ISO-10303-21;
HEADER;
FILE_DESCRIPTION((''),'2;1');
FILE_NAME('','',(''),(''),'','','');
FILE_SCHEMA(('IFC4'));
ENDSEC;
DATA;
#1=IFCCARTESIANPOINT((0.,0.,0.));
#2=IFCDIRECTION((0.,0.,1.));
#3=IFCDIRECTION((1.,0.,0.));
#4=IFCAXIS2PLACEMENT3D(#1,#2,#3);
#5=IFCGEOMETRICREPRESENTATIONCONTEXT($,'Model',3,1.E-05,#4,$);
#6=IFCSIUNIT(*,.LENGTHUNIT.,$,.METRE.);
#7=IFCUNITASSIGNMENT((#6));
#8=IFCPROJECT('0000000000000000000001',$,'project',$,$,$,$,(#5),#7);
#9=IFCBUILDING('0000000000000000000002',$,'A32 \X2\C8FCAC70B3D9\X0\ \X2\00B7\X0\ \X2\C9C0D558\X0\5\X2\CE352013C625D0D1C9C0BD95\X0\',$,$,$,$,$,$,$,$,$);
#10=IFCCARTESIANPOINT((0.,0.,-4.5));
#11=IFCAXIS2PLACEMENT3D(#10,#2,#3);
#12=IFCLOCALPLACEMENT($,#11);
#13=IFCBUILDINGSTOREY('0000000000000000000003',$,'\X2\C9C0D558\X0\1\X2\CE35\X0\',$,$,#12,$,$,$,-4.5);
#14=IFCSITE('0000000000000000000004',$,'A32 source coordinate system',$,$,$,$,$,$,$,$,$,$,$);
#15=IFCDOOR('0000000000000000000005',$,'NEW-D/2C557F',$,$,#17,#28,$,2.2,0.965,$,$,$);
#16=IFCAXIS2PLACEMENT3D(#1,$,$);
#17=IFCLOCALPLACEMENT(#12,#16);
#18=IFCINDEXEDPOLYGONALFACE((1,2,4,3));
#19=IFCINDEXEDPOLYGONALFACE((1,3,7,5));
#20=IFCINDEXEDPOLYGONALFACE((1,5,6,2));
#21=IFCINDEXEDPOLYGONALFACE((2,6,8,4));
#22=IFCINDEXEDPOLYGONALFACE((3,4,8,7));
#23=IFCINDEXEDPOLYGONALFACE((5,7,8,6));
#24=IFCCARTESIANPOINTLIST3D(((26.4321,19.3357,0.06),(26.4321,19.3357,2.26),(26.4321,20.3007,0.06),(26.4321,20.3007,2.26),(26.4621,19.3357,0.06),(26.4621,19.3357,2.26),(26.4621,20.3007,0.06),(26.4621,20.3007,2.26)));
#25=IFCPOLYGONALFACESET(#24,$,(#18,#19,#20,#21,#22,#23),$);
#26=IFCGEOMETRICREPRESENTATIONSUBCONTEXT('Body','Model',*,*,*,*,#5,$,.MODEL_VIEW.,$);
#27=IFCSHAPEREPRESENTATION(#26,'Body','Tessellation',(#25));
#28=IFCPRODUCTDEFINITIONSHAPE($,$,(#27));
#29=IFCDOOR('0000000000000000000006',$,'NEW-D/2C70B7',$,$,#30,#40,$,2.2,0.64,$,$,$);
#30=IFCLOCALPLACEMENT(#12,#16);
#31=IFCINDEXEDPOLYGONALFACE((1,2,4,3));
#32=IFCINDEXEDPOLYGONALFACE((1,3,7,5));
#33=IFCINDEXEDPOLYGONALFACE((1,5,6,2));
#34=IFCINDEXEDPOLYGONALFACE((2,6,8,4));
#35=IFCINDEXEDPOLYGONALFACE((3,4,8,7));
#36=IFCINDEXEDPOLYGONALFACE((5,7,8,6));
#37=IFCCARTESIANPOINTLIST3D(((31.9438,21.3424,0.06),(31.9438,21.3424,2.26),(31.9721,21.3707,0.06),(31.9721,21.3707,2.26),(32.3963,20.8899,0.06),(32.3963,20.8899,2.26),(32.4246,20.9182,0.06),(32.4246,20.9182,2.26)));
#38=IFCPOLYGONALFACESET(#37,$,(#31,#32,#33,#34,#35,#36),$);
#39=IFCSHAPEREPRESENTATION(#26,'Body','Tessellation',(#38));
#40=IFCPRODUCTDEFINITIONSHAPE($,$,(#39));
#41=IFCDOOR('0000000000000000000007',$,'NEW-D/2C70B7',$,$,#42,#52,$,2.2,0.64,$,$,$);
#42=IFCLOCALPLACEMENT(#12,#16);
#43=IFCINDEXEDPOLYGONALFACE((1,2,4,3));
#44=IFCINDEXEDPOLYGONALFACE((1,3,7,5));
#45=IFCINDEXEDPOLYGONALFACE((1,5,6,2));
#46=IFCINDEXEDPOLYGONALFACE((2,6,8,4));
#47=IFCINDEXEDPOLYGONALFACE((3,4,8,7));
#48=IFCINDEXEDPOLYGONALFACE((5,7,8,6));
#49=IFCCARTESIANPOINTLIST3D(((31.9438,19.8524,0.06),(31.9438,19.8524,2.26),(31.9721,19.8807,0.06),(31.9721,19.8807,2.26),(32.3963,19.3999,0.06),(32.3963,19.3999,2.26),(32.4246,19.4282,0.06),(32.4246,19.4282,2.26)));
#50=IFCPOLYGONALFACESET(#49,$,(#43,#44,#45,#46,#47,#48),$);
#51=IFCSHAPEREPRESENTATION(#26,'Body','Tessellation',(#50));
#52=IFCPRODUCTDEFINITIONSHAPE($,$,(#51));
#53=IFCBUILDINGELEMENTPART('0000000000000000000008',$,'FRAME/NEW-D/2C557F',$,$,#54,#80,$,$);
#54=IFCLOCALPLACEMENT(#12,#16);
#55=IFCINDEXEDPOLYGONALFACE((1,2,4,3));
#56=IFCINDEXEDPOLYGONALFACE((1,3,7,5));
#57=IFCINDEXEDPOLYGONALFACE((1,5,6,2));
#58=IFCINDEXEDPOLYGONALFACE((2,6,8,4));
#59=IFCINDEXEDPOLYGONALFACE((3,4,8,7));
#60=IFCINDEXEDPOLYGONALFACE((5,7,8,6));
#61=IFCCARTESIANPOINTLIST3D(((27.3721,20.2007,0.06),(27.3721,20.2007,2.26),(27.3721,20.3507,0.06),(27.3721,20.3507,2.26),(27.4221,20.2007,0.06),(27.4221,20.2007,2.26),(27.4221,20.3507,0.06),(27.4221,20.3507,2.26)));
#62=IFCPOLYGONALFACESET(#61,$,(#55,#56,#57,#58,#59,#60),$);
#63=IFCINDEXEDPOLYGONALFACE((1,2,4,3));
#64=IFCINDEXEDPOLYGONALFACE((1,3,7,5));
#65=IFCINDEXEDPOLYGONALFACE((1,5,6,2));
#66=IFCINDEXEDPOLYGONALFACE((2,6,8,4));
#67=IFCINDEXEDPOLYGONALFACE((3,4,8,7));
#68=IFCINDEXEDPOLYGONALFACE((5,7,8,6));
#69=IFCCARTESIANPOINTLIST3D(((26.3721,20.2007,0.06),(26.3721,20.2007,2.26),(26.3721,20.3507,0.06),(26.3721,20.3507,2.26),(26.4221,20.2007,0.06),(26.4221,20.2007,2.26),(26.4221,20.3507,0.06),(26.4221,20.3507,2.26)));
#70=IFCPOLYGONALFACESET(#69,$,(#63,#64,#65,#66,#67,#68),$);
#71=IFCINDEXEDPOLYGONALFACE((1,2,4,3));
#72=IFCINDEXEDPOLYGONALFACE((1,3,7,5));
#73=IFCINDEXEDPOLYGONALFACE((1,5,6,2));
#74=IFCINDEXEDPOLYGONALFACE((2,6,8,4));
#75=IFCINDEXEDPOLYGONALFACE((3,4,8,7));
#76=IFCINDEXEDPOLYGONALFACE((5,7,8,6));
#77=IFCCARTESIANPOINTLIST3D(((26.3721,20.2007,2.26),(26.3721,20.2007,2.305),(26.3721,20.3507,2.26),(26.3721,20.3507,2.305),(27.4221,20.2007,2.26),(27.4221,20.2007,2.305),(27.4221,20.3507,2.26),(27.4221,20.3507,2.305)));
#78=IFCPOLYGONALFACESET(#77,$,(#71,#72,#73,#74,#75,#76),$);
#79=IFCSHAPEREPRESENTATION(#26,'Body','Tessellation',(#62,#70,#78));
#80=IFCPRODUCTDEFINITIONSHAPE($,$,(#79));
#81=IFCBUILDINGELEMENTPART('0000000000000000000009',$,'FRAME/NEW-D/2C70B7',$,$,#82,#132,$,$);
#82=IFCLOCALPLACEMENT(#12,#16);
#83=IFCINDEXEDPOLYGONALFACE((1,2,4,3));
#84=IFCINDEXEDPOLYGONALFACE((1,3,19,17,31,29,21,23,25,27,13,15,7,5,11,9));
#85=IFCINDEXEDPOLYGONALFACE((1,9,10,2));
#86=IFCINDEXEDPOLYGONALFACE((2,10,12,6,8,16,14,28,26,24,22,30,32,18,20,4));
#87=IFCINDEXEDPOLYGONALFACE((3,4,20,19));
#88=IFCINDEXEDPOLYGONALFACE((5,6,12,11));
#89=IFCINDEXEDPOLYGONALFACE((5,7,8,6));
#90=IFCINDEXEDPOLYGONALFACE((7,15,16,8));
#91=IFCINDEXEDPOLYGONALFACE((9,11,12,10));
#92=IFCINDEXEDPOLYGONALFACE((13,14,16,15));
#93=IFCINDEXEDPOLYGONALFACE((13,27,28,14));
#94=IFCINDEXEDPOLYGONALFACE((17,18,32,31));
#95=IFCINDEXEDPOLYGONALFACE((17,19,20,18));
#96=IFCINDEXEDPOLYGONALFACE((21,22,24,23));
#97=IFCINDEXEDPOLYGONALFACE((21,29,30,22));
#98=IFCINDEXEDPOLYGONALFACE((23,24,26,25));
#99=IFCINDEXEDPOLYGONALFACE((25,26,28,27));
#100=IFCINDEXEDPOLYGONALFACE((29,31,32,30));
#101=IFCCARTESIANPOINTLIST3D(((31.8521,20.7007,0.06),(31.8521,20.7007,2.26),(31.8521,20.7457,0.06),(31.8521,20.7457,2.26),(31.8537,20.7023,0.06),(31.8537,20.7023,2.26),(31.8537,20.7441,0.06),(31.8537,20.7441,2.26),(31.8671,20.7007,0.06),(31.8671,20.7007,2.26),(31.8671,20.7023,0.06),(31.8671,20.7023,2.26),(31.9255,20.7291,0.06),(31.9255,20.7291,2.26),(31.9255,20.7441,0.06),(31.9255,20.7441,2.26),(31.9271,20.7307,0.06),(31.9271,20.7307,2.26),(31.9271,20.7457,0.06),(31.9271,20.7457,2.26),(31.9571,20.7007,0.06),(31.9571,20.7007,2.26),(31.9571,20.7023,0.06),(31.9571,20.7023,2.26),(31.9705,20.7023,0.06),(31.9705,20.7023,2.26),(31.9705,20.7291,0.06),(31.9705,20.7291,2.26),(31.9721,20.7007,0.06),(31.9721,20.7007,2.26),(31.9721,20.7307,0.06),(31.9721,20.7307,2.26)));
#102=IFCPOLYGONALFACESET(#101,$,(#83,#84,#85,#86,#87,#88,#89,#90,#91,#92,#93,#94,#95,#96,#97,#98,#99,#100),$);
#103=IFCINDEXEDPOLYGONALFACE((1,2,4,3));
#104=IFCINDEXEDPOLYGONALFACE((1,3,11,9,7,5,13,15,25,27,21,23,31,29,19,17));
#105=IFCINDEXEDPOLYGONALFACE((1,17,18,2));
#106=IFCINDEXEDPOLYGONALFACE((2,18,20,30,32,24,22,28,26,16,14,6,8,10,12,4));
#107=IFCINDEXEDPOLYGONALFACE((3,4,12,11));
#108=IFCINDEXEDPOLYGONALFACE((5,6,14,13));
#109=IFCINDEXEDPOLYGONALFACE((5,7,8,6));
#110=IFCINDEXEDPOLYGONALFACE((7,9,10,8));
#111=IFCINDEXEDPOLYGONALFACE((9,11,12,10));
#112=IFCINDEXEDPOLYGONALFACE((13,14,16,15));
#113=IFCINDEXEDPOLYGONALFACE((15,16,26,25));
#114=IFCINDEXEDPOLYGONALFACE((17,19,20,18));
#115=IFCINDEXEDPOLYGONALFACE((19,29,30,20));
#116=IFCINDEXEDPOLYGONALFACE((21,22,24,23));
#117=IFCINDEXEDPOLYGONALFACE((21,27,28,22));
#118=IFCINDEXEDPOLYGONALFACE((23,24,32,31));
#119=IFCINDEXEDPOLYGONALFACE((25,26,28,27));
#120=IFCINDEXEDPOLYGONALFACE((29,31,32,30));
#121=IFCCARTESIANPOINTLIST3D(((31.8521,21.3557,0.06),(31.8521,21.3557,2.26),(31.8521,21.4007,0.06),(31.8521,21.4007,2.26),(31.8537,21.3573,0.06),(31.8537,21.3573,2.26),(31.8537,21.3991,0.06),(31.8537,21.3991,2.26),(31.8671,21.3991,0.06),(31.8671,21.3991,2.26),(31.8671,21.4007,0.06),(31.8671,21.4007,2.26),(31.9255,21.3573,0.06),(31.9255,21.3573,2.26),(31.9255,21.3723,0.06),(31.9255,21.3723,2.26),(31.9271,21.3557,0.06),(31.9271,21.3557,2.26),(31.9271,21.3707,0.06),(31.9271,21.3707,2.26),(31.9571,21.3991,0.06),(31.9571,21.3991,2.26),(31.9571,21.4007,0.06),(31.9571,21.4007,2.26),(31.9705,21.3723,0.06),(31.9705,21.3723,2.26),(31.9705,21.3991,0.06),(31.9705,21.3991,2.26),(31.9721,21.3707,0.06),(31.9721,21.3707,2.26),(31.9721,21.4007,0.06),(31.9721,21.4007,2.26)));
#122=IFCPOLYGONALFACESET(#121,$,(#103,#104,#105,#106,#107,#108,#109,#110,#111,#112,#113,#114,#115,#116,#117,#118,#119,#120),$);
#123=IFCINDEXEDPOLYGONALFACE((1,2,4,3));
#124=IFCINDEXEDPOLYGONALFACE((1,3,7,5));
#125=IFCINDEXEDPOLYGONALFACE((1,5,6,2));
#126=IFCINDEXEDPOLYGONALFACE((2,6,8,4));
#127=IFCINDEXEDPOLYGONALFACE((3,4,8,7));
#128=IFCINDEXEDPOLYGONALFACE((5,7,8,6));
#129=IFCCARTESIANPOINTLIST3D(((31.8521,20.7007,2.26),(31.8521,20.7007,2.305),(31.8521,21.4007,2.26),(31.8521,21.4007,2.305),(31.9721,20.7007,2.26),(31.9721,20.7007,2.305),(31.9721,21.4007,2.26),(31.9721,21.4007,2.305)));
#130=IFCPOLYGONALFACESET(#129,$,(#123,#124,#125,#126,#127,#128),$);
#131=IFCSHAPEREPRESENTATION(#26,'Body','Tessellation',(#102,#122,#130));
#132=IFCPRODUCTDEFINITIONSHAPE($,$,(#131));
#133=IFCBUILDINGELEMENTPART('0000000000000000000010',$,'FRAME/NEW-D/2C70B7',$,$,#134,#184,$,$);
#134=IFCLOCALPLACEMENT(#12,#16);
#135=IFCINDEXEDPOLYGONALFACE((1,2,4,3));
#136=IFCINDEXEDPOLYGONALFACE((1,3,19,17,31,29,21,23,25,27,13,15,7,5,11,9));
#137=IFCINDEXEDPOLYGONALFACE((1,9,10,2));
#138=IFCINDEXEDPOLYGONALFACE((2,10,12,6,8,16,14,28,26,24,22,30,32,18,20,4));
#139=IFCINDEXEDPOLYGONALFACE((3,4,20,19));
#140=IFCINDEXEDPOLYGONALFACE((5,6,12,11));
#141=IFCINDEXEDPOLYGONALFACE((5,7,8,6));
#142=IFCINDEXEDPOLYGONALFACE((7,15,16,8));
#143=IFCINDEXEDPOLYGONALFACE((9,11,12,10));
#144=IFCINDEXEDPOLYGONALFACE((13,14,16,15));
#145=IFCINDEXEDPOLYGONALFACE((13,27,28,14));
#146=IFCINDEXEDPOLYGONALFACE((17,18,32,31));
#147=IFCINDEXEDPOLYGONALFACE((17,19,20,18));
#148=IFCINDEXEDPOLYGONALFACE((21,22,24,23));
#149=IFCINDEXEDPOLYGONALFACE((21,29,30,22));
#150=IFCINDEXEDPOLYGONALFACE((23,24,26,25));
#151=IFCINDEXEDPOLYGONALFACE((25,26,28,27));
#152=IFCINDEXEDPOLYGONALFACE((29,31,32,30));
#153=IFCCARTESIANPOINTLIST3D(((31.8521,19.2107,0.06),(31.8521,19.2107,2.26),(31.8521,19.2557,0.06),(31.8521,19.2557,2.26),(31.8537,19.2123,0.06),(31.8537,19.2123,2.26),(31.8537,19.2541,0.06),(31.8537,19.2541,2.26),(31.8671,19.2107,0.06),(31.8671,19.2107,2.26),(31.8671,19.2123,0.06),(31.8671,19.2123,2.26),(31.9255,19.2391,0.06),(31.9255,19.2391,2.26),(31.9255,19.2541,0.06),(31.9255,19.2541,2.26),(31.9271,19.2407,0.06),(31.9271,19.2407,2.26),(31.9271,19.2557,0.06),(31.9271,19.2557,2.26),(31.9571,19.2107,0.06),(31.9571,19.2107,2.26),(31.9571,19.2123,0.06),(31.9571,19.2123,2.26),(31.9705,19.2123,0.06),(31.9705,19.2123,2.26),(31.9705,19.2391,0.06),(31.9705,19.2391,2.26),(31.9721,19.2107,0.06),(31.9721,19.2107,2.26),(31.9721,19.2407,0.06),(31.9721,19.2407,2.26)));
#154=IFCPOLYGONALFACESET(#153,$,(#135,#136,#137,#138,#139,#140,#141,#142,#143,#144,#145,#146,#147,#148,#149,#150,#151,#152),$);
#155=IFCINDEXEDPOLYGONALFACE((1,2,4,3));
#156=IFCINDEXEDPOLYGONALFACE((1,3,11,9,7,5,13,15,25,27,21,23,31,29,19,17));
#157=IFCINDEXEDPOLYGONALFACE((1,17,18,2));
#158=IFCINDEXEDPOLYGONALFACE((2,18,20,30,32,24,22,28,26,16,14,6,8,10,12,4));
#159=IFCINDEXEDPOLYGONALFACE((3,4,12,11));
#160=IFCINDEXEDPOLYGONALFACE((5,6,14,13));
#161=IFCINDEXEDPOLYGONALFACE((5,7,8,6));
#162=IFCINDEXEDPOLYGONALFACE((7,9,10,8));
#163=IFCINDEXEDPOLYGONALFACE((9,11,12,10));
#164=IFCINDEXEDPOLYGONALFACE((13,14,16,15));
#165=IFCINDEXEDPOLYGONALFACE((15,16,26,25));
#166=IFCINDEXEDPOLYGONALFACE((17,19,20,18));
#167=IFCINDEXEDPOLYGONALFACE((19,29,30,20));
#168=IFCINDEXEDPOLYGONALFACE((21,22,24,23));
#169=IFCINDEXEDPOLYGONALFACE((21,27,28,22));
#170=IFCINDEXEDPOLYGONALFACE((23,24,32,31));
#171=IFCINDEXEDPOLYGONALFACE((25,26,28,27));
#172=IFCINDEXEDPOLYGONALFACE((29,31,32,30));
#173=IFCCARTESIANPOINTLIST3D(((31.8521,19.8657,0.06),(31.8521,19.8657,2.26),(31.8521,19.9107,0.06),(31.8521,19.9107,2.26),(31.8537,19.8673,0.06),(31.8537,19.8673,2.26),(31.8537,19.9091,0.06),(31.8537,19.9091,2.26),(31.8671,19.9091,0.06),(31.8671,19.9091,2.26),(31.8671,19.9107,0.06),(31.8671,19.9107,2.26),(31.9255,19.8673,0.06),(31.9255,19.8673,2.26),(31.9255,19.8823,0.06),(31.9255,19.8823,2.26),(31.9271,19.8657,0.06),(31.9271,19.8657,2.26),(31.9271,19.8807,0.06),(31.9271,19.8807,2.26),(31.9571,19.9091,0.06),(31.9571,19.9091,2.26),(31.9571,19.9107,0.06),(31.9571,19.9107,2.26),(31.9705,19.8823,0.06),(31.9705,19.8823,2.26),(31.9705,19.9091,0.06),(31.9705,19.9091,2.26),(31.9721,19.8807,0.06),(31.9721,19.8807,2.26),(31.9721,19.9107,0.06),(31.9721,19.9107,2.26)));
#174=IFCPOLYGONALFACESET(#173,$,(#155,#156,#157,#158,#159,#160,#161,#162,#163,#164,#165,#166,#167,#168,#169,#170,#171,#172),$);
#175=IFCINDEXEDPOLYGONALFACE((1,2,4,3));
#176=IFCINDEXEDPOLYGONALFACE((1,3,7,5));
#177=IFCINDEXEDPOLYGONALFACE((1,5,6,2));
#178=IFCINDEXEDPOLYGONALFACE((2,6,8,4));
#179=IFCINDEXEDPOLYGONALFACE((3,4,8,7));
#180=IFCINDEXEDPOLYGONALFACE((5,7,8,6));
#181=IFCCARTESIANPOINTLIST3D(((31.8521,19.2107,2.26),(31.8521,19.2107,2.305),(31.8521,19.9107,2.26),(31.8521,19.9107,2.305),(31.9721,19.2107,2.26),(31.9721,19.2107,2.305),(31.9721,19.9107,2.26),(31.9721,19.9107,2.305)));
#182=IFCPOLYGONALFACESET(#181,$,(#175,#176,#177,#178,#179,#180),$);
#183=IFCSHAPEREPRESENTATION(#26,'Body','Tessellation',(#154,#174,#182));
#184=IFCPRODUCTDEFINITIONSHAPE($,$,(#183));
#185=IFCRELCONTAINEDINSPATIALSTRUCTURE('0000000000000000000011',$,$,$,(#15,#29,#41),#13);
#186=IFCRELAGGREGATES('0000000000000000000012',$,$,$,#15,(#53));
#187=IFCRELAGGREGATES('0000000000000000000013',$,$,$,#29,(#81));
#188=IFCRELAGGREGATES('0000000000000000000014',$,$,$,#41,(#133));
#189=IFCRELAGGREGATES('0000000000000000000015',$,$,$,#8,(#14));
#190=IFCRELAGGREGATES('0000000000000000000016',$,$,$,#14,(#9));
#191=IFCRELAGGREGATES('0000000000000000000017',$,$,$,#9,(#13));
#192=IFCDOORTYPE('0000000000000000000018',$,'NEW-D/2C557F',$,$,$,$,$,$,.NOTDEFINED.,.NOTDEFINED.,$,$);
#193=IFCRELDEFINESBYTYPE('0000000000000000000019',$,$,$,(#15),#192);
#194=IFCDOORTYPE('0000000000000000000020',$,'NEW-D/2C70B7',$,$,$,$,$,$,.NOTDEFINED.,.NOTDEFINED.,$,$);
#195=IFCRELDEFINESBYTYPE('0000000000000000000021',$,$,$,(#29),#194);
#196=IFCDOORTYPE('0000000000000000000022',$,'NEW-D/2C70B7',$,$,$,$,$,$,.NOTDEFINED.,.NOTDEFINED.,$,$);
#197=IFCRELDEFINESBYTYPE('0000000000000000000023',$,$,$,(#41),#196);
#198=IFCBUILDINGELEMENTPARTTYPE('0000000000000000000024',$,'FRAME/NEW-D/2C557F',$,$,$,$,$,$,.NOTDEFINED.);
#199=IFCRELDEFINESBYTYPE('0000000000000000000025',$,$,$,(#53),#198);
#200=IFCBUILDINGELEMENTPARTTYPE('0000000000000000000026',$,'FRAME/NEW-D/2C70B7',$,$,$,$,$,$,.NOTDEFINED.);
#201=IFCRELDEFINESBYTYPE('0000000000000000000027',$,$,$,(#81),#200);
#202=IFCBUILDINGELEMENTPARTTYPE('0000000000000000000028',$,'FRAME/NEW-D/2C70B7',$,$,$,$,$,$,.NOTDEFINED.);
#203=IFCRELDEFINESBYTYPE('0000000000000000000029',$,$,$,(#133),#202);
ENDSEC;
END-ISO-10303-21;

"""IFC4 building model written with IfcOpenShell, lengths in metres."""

from ifc_helpers import new_model, si_unit, frame, origin, origin_with_axes, place, context, subcontext, project, spatial, polyline, outline, extrude, source, transform, mapped, type_object, type_shapes, element, aggregate, save


model = new_model("IFC4")

# Units and contexts
model_context = context("Model", 3, precision=1e-05, world=origin_with_axes())
body_context = subcontext(model_context, "Body", "Model", "MODEL_VIEW")
ifc_project = project(units=[si_unit("LENGTHUNIT", "METRE")], contexts=[model_context])

# Site, building, storey
site = spatial("IfcSite", under=ifc_project, Name="A32 source coordinate system")
building = spatial("IfcBuilding", under=site, Name="A32 주거동 · 지하5층–옥탑지붕")
storey_placement = place(None, frame((0.0, 0.0, -4.5), z_axis=(0.0, 0.0, 1.0), x_axis=(1.0, 0.0, 0.0)))
storey = spatial("IfcBuildingStorey", under=building, at=storey_placement, Name="지하1층", Elevation=-4.5)

# Doors
door_type_1 = type_object("IfcDoorType", Name="NEW-D/2C557F", OperationType="NOTDEFINED", PredefinedType="NOTDEFINED")
shared_shape_1 = source(origin(), body_context, "Body", "SweptSolid", [
    extrude(outline(polyline([(26.4621, 20.3007), (26.4621, 19.3357), (26.4321, 19.3357), (26.4321, 20.3007), (26.4621, 20.3007)])), frame((0.0, 0.0, 0.06)), (0.0, 0.0, 1.0), 2.2),
])
type_shapes(door_type_1, [shared_shape_1])
door_1_placement = place(storey_placement, origin_with_axes())
door_1 = element("IfcDoor", 1, at=door_1_placement, inside=storey, type_object=door_type_1, Name="NEW-D/2C557F", OverallHeight=2.2, OverallWidth=0.965, context=body_context, shape_type="MappedRepresentation", body=[
    mapped(shared_shape_1, transform((0.0, 0.0, 0.0), scale=1.0)),
])
door_type_2 = type_object("IfcDoorType", Name="NEW-D/2C70B7", OperationType="NOTDEFINED", PredefinedType="NOTDEFINED")
shared_shape_2 = source(origin(), body_context, "Body", "SweptSolid", [
    extrude(outline(polyline([(32.3963, 20.8899), (31.9438, 21.3424), (31.9721, 21.3707), (32.4246, 20.9182), (32.3963, 20.8899)])), frame((0.0, 0.0, 0.06)), (0.0, 0.0, 1.0), 2.2),
])
type_shapes(door_type_2, [shared_shape_2])
door_2_placement = place(storey_placement, origin_with_axes())
door_2 = element("IfcDoor", 2, at=door_2_placement, inside=storey, type_object=door_type_2, Name="NEW-D/2C70B7", OverallHeight=2.2, OverallWidth=0.64, context=body_context, shape_type="MappedRepresentation", body=[
    mapped(shared_shape_2, transform((0.0, 0.0, 0.0), scale=1.0)),
])
door_type_3 = type_object("IfcDoorType", Name="NEW-D/2C70B7", OperationType="NOTDEFINED", PredefinedType="NOTDEFINED")
shared_shape_3 = source(origin(), body_context, "Body", "SweptSolid", [
    extrude(outline(polyline([(32.3963, 19.3999), (31.9438, 19.8524), (31.9721, 19.8807), (32.4246, 19.4282), (32.3963, 19.3999)])), frame((0.0, 0.0, 0.06)), (0.0, 0.0, 1.0), 2.2),
])
type_shapes(door_type_3, [shared_shape_3])
door_3_placement = place(storey_placement, origin_with_axes())
door_3 = element("IfcDoor", 3, at=door_3_placement, inside=storey, type_object=door_type_3, Name="NEW-D/2C70B7", OverallHeight=2.2, OverallWidth=0.64, context=body_context, shape_type="MappedRepresentation", body=[
    mapped(shared_shape_3, transform((0.0, 0.0, 0.0), scale=1.0)),
])

# Building element parts
building_element_part_type_1 = type_object("IfcBuildingElementPartType", Name="FRAME/NEW-D/2C557F", PredefinedType="NOTDEFINED")
shared_shape_4 = source(origin(), body_context, "Body", "SweptSolid", [
    extrude(outline(polyline([(27.4221, 20.2007), (27.3721, 20.2007), (27.3721, 20.3507), (27.4221, 20.3507), (27.4221, 20.2007)])), frame((0.0, 0.0, 0.06)), (0.0, 0.0, 1.0), 2.2),
    extrude(outline(polyline([(26.4221, 20.2007), (26.3721, 20.2007), (26.3721, 20.3507), (26.4221, 20.3507), (26.4221, 20.2007)])), frame((0.0, 0.0, 0.06)), (0.0, 0.0, 1.0), 2.2),
    extrude(outline(polyline([(27.4221, 20.2007), (27.4221, 20.3507), (26.3721, 20.3507), (26.3721, 20.2007), (27.4221, 20.2007)])), frame((0.0, 0.0, 2.26)), (0.0, 0.0, 1.0), 0.045),
])
type_shapes(building_element_part_type_1, [shared_shape_4])
building_element_part_1_placement = place(door_1_placement, origin_with_axes())
building_element_part_1 = element("IfcBuildingElementPart", 4, at=building_element_part_1_placement, type_object=building_element_part_type_1, Name="FRAME/NEW-D/2C557F", context=body_context, shape_type="MappedRepresentation", body=[
    mapped(shared_shape_4, transform((0.0, 0.0, 0.0), scale=1.0)),
])
aggregate(door_1, [building_element_part_1])
building_element_part_type_2 = type_object("IfcBuildingElementPartType", Name="FRAME/NEW-D/2C70B7", PredefinedType="NOTDEFINED")
shared_shape_5 = source(origin(), body_context, "Body", "SweptSolid", [
    extrude(outline(polyline([(31.9705, 20.7291), (31.9255, 20.7291), (31.9255, 20.7441), (31.8537, 20.7441), (31.8537, 20.7023), (31.8671, 20.7023), (31.8671, 20.7007), (31.8521, 20.7007), (31.8521, 20.7457), (31.9271, 20.7457), (31.9271, 20.7307), (31.9721, 20.7307), (31.9721, 20.7007), (31.9571, 20.7007), (31.9571, 20.7023), (31.9705, 20.7023), (31.9705, 20.7291)])), frame((0.0, 0.0, 0.06)), (0.0, 0.0, 1.0), 2.2),
    extrude(outline(polyline([(31.9721, 21.4007), (31.9721, 21.3707), (31.9271, 21.3707), (31.9271, 21.3557), (31.8521, 21.3557), (31.8521, 21.4007), (31.8671, 21.4007), (31.8671, 21.3991), (31.8537, 21.3991), (31.8537, 21.3573), (31.9255, 21.3573), (31.9255, 21.3723), (31.9705, 21.3723), (31.9705, 21.3991), (31.9571, 21.3991), (31.9571, 21.4007), (31.9721, 21.4007)])), frame((0.0, 0.0, 0.06)), (0.0, 0.0, 1.0), 2.2),
    extrude(outline(polyline([(31.9721, 20.7007), (31.9721, 21.4007), (31.8521, 21.4007), (31.8521, 20.7007), (31.9721, 20.7007)])), frame((0.0, 0.0, 2.26)), (0.0, 0.0, 1.0), 0.045),
])
type_shapes(building_element_part_type_2, [shared_shape_5])
building_element_part_2_placement = place(door_2_placement, origin_with_axes())
building_element_part_2 = element("IfcBuildingElementPart", 5, at=building_element_part_2_placement, type_object=building_element_part_type_2, Name="FRAME/NEW-D/2C70B7", context=body_context, shape_type="MappedRepresentation", body=[
    mapped(shared_shape_5, transform((0.0, 0.0, 0.0), scale=1.0)),
])
aggregate(door_2, [building_element_part_2])
building_element_part_type_3 = type_object("IfcBuildingElementPartType", Name="FRAME/NEW-D/2C70B7", PredefinedType="NOTDEFINED")
shared_shape_6 = source(origin(), body_context, "Body", "SweptSolid", [
    extrude(outline(polyline([(31.9705, 19.2391), (31.9255, 19.2391), (31.9255, 19.2541), (31.8537, 19.2541), (31.8537, 19.2123), (31.8671, 19.2123), (31.8671, 19.2107), (31.8521, 19.2107), (31.8521, 19.2557), (31.9271, 19.2557), (31.9271, 19.2407), (31.9721, 19.2407), (31.9721, 19.2107), (31.9571, 19.2107), (31.9571, 19.2123), (31.9705, 19.2123), (31.9705, 19.2391)])), frame((0.0, 0.0, 0.06)), (0.0, 0.0, 1.0), 2.2),
    extrude(outline(polyline([(31.9721, 19.9107), (31.9721, 19.8807), (31.9271, 19.8807), (31.9271, 19.8657), (31.8521, 19.8657), (31.8521, 19.9107), (31.8671, 19.9107), (31.8671, 19.9091), (31.8537, 19.9091), (31.8537, 19.8673), (31.9255, 19.8673), (31.9255, 19.8823), (31.9705, 19.8823), (31.9705, 19.9091), (31.9571, 19.9091), (31.9571, 19.9107), (31.9721, 19.9107)])), frame((0.0, 0.0, 0.06)), (0.0, 0.0, 1.0), 2.2),
    extrude(outline(polyline([(31.9721, 19.2107), (31.9721, 19.9107), (31.8521, 19.9107), (31.8521, 19.2107), (31.9721, 19.2107)])), frame((0.0, 0.0, 2.26)), (0.0, 0.0, 1.0), 0.045),
])
type_shapes(building_element_part_type_3, [shared_shape_6])
building_element_part_3_placement = place(door_3_placement, origin_with_axes())
building_element_part_3 = element("IfcBuildingElementPart", 6, at=building_element_part_3_placement, type_object=building_element_part_type_3, Name="FRAME/NEW-D/2C70B7", context=body_context, shape_type="MappedRepresentation", body=[
    mapped(shared_shape_6, transform((0.0, 0.0, 0.0), scale=1.0)),
])
aggregate(door_3, [building_element_part_3])

save(model, "model.ifc")
